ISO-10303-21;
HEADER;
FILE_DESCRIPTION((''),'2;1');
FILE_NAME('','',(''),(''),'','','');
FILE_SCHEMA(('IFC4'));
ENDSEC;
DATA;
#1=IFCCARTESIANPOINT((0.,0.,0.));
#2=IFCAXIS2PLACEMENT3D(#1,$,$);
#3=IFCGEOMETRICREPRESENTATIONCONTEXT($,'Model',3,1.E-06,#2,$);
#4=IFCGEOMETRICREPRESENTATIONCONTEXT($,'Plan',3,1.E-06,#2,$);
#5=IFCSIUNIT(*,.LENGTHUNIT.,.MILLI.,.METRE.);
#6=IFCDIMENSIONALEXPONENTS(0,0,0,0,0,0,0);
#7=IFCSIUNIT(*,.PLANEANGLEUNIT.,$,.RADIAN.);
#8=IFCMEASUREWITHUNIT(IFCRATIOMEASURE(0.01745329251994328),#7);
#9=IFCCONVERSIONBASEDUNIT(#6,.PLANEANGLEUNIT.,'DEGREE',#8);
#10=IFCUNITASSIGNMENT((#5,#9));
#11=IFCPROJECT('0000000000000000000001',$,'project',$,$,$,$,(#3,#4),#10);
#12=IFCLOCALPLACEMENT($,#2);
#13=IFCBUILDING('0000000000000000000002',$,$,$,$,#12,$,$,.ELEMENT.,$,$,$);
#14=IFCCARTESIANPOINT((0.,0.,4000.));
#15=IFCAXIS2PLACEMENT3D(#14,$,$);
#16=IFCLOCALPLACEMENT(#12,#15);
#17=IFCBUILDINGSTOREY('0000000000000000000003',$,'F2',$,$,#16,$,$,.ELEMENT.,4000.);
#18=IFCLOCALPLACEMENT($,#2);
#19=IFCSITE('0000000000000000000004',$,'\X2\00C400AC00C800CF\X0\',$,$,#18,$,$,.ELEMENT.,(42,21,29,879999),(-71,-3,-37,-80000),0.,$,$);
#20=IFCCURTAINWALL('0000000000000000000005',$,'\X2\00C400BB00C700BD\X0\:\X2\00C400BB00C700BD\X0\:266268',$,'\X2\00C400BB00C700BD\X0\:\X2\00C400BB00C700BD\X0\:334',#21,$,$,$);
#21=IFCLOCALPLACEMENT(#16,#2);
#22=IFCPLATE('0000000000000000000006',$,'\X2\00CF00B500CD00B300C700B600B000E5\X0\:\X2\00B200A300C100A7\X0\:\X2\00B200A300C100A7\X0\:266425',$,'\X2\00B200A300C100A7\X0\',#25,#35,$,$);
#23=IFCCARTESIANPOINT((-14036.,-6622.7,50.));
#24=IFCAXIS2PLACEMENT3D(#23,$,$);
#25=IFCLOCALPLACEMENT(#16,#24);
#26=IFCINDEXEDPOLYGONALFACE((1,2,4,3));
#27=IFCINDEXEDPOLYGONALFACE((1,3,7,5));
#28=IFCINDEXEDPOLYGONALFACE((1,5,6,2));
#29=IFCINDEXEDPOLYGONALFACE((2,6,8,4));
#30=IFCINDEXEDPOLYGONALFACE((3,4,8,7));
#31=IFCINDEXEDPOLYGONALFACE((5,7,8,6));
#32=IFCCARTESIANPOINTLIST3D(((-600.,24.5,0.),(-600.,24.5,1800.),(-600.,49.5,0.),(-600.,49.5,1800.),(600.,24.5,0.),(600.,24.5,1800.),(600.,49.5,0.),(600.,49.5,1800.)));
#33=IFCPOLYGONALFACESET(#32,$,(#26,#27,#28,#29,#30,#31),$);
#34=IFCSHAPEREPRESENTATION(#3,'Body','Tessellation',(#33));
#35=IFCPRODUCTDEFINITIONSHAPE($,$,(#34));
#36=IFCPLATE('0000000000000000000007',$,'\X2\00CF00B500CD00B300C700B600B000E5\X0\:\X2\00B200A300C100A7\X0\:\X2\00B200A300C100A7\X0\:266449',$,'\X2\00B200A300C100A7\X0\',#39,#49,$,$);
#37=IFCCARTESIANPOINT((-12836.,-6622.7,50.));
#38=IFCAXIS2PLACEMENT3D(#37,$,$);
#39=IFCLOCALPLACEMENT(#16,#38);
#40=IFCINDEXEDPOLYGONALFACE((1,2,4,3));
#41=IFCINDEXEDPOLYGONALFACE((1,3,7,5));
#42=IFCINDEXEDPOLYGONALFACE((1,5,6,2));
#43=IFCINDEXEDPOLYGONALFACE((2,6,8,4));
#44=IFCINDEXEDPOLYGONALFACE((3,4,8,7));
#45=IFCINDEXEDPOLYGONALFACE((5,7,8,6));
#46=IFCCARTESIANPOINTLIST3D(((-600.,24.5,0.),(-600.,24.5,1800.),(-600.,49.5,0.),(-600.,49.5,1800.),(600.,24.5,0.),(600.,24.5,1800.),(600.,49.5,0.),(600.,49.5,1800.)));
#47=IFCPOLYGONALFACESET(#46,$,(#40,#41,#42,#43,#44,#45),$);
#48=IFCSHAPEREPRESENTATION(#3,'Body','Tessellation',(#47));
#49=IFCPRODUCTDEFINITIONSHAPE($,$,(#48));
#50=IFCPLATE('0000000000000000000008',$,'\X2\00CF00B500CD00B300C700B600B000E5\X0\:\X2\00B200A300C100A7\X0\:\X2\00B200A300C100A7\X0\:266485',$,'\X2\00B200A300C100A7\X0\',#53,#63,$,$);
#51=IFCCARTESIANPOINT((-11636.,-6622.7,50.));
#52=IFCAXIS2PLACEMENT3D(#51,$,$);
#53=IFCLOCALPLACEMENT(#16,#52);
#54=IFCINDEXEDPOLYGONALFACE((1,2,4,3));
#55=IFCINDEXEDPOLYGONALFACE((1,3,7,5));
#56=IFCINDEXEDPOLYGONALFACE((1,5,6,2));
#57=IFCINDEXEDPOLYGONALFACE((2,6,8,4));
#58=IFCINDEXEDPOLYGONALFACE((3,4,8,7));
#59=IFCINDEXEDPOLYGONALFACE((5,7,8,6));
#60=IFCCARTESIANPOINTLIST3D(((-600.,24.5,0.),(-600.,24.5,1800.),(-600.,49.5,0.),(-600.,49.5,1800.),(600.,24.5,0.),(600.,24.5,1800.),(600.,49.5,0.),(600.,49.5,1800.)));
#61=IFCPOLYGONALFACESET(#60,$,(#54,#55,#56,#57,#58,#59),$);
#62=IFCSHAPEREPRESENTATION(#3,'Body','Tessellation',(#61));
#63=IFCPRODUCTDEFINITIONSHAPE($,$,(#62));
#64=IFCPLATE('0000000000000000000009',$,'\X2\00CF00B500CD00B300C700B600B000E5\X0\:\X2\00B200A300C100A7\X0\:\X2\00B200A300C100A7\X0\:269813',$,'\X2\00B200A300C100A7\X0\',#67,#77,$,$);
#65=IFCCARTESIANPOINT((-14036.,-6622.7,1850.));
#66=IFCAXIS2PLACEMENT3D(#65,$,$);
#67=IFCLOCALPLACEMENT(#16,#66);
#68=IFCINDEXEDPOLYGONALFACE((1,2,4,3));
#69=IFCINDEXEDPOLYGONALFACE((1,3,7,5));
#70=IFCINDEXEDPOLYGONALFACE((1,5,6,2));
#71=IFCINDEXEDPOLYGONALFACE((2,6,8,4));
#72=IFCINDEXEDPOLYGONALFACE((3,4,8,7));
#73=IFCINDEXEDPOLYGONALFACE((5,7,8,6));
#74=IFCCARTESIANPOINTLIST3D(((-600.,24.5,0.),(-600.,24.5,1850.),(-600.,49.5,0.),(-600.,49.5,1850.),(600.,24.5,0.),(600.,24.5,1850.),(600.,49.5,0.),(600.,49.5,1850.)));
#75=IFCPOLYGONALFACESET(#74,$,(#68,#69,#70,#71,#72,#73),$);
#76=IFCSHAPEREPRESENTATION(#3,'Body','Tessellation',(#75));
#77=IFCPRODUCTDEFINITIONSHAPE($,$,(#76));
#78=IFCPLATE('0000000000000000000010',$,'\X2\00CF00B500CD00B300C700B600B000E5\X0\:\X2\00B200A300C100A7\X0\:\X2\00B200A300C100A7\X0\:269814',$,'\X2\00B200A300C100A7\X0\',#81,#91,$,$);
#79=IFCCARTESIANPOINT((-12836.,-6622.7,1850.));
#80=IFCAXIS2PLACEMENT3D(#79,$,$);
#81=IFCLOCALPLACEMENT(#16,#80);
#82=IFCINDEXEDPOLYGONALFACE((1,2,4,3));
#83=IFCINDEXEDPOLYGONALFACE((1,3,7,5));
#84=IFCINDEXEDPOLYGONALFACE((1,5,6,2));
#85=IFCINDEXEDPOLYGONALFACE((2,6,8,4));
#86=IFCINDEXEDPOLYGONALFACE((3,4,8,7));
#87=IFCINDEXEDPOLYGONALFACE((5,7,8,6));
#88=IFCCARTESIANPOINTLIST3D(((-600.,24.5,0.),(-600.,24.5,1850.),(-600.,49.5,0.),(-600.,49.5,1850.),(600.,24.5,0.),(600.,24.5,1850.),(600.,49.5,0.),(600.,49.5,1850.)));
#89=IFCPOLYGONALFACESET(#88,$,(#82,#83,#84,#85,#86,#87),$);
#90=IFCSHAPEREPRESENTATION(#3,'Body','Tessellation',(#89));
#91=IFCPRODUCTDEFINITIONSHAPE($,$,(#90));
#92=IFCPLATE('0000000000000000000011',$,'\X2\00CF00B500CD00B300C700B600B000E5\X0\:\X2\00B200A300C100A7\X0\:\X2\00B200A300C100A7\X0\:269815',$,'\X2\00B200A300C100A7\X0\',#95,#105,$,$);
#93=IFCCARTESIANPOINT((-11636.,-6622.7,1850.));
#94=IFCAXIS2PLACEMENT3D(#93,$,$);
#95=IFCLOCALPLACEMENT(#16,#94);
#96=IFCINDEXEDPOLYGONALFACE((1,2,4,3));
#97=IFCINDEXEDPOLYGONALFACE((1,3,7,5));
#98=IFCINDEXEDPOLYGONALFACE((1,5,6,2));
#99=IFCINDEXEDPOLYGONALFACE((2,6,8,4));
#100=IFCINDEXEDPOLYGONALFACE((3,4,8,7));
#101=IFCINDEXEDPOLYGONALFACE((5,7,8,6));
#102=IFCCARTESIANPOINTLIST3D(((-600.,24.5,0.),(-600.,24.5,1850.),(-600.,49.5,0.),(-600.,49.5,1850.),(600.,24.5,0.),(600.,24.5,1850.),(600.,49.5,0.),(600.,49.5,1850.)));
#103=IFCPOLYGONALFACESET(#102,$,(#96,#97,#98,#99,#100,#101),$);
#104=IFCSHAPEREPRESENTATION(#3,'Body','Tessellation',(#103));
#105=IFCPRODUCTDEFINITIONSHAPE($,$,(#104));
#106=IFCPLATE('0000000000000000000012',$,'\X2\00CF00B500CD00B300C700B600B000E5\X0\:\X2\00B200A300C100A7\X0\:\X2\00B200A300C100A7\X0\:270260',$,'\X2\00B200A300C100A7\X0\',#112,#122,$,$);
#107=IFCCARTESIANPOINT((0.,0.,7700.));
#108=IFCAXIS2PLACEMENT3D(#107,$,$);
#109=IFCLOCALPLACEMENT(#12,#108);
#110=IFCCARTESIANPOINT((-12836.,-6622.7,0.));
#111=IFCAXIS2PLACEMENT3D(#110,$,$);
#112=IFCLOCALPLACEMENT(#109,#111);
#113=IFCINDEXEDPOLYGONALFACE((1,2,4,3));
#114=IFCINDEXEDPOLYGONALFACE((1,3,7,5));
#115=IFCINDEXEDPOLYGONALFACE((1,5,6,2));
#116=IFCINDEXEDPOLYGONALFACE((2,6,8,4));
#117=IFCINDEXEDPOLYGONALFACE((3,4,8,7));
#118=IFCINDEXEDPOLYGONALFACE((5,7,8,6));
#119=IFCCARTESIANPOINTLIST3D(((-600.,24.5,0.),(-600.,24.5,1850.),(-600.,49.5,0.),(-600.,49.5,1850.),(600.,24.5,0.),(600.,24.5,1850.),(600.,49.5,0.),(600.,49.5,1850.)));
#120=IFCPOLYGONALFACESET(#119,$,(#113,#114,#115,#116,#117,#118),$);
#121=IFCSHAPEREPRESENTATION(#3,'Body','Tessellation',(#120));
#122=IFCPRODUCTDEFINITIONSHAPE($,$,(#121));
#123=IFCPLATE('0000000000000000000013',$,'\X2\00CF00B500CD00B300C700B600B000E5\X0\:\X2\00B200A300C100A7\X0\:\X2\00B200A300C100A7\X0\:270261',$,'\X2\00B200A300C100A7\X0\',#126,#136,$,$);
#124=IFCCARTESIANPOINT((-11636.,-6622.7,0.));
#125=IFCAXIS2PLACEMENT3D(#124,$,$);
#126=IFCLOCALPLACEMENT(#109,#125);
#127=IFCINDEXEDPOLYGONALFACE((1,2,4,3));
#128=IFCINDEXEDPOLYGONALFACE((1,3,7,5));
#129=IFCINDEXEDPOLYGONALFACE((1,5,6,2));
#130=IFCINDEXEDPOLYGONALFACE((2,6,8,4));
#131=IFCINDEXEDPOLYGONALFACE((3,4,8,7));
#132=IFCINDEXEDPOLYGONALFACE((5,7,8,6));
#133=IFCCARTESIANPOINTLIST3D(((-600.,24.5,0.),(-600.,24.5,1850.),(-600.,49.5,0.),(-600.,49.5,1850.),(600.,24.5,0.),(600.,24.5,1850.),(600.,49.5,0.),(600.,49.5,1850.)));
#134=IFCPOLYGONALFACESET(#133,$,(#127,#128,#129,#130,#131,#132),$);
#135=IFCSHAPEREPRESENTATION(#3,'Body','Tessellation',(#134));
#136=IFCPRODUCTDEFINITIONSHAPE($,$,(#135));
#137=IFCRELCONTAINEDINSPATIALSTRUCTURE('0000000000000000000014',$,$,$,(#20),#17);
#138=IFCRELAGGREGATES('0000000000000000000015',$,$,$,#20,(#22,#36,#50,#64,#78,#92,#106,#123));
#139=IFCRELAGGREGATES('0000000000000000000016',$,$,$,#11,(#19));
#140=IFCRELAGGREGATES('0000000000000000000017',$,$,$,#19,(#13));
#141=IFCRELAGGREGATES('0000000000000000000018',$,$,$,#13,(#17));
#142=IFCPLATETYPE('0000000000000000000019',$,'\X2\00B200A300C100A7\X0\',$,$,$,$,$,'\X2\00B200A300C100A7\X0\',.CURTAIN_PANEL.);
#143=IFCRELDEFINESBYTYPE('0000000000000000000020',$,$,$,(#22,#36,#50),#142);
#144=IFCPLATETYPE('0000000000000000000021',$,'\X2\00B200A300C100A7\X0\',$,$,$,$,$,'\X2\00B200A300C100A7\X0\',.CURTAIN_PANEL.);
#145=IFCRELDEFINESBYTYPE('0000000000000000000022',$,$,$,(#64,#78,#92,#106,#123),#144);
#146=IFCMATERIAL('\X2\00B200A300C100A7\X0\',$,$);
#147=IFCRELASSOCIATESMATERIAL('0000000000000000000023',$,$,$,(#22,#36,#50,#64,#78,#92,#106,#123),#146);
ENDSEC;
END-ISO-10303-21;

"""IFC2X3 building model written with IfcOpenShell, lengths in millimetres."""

from ifc_helpers import new_model, entity, si_unit, converted_unit, frame, origin, origin_2d_with_axis, place, context, project, spatial, rectangle, extrude, source, transform, mapped, material, type_object, type_shapes, element, aggregate, save


model = new_model("IFC2X3")

# Units and contexts
model_context = context("Model", 3, precision=1e-06, world=origin())
plan_context = context("Plan", 3, precision=1e-06, world=origin())
ifc_project = project(units=[si_unit("LENGTHUNIT", "METRE", prefix="MILLI"), converted_unit("PLANEANGLEUNIT", "DEGREE", entity("IfcRatioMeasure", 0.01745329251994328), si_unit("PLANEANGLEUNIT", "RADIAN"), dimensions=[0, 0, 0, 0, 0, 0, 0])], contexts=[model_context, plan_context])

# Site, building, storey
site_placement = place(None, origin())
site = spatial("IfcSite", under=ifc_project, at=site_placement, Name="Ä¬ÈÏ", CompositionType="ELEMENT", RefLatitude=(42, 21, 29, 879999), RefLongitude=(-71, -3, -37, -80000), RefElevation=0.0)
building_placement = place(None, origin())
building = spatial("IfcBuilding", under=site, at=building_placement, CompositionType="ELEMENT")
storey_placement = place(building_placement, frame((0.0, 0.0, 4000.0)))
storey = spatial("IfcBuildingStorey", under=building, at=storey_placement, Name="F2", CompositionType="ELEMENT", Elevation=4000.0)

# Curtain wall, plates
curtain_wall_placement = place(storey_placement, origin())
curtain_wall = element("IfcCurtainWall", 1, at=curtain_wall_placement, inside=storey, Name="Ä»Ç½:Ä»Ç½:266268", ObjectType="Ä»Ç½:Ä»Ç½:334")
placement = place(building_placement, frame((0.0, 0.0, 7700.0)))
ifc_material_1 = material(Name="²£Á§")
plate_type_1 = type_object("IfcPlateType", Name="²£Á§", ElementType="²£Á§", PredefinedType="CURTAIN_PANEL")
shared_shape_1 = source(origin(), model_context, "Body", "SweptSolid", [
    extrude(rectangle(XDim=25.0, YDim=1200.0, at=origin_2d_with_axis()), frame((0.0, 37.0, 0.0), z_axis=(0.0, 0.0, 1.0), x_axis=(0.0, 1.0, 0.0)), (0.0, 0.0, 1.0), 1800.0),
])
type_shapes(plate_type_1, [shared_shape_1])
plate_1_placement = place(storey_placement, frame((-14036.0, -6622.7, 50.0)))
plate_1 = element("IfcPlate", 2, at=plate_1_placement, type_object=plate_type_1, material=ifc_material_1, Name="ÏµÍ³Ç¶°å:²£Á§:²£Á§:266425", ObjectType="²£Á§", context=model_context, shape_type="MappedRepresentation", body=[
    mapped(shared_shape_1, transform((0.0, 0.0, 0.0), scale=1.0)),
])
plate_2_placement = place(storey_placement, frame((-12836.0, -6622.7, 50.0)))
plate_2 = element("IfcPlate", 3, at=plate_2_placement, type_object=plate_type_1, material=ifc_material_1, Name="ÏµÍ³Ç¶°å:²£Á§:²£Á§:266449", ObjectType="²£Á§", context=model_context, shape_type="MappedRepresentation", body=[
    mapped(shared_shape_1, transform((0.0, 0.0, 0.0), scale=1.0)),
])
plate_3_placement = place(storey_placement, frame((-11636.0, -6622.7, 50.0)))
plate_3 = element("IfcPlate", 4, at=plate_3_placement, type_object=plate_type_1, material=ifc_material_1, Name="ÏµÍ³Ç¶°å:²£Á§:²£Á§:266485", ObjectType="²£Á§", context=model_context, shape_type="MappedRepresentation", body=[
    mapped(shared_shape_1, transform((0.0, 0.0, 0.0), scale=1.0)),
])
plate_type_2 = type_object("IfcPlateType", Name="²£Á§", ElementType="²£Á§", PredefinedType="CURTAIN_PANEL")
shared_shape_2 = source(origin(), model_context, "Body", "SweptSolid", [
    extrude(rectangle(XDim=25.0, YDim=1200.0, at=origin_2d_with_axis()), frame((0.0, 37.0, 0.0), z_axis=(0.0, 0.0, 1.0), x_axis=(0.0, 1.0, 0.0)), (0.0, 0.0, 1.0), 1850.0),
])
type_shapes(plate_type_2, [shared_shape_2])
plate_4_placement = place(storey_placement, frame((-14036.0, -6622.7, 1850.0)))
plate_4 = element("IfcPlate", 5, at=plate_4_placement, type_object=plate_type_2, material=ifc_material_1, Name="ÏµÍ³Ç¶°å:²£Á§:²£Á§:269813", ObjectType="²£Á§", context=model_context, shape_type="MappedRepresentation", body=[
    mapped(shared_shape_2, transform((0.0, 0.0, 0.0), scale=1.0)),
])
plate_5_placement = place(storey_placement, frame((-12836.0, -6622.7, 1850.0)))
plate_5 = element("IfcPlate", 6, at=plate_5_placement, type_object=plate_type_2, material=ifc_material_1, Name="ÏµÍ³Ç¶°å:²£Á§:²£Á§:269814", ObjectType="²£Á§", context=model_context, shape_type="MappedRepresentation", body=[
    mapped(shared_shape_2, transform((0.0, 0.0, 0.0), scale=1.0)),
])
plate_6_placement = place(storey_placement, frame((-11636.0, -6622.7, 1850.0)))
plate_6 = element("IfcPlate", 7, at=plate_6_placement, type_object=plate_type_2, material=ifc_material_1, Name="ÏµÍ³Ç¶°å:²£Á§:²£Á§:269815", ObjectType="²£Á§", context=model_context, shape_type="MappedRepresentation", body=[
    mapped(shared_shape_2, transform((0.0, 0.0, 0.0), scale=1.0)),
])
plate_7_placement = place(placement, frame((-12836.0, -6622.7, 0.0)))
plate_7 = element("IfcPlate", 8, at=plate_7_placement, type_object=plate_type_2, material=ifc_material_1, Name="ÏµÍ³Ç¶°å:²£Á§:²£Á§:270260", ObjectType="²£Á§", context=model_context, shape_type="MappedRepresentation", body=[
    mapped(shared_shape_2, transform((0.0, 0.0, 0.0), scale=1.0)),
])
plate_8_placement = place(placement, frame((-11636.0, -6622.7, 0.0)))
plate_8 = element("IfcPlate", 9, at=plate_8_placement, type_object=plate_type_2, material=ifc_material_1, Name="ÏµÍ³Ç¶°å:²£Á§:²£Á§:270261", ObjectType="²£Á§", context=model_context, shape_type="MappedRepresentation", body=[
    mapped(shared_shape_2, transform((0.0, 0.0, 0.0), scale=1.0)),
])
aggregate(curtain_wall, [plate_1, plate_2, plate_3, plate_4, plate_5, plate_6, plate_7, plate_8])

save(model, "model.ifc")
